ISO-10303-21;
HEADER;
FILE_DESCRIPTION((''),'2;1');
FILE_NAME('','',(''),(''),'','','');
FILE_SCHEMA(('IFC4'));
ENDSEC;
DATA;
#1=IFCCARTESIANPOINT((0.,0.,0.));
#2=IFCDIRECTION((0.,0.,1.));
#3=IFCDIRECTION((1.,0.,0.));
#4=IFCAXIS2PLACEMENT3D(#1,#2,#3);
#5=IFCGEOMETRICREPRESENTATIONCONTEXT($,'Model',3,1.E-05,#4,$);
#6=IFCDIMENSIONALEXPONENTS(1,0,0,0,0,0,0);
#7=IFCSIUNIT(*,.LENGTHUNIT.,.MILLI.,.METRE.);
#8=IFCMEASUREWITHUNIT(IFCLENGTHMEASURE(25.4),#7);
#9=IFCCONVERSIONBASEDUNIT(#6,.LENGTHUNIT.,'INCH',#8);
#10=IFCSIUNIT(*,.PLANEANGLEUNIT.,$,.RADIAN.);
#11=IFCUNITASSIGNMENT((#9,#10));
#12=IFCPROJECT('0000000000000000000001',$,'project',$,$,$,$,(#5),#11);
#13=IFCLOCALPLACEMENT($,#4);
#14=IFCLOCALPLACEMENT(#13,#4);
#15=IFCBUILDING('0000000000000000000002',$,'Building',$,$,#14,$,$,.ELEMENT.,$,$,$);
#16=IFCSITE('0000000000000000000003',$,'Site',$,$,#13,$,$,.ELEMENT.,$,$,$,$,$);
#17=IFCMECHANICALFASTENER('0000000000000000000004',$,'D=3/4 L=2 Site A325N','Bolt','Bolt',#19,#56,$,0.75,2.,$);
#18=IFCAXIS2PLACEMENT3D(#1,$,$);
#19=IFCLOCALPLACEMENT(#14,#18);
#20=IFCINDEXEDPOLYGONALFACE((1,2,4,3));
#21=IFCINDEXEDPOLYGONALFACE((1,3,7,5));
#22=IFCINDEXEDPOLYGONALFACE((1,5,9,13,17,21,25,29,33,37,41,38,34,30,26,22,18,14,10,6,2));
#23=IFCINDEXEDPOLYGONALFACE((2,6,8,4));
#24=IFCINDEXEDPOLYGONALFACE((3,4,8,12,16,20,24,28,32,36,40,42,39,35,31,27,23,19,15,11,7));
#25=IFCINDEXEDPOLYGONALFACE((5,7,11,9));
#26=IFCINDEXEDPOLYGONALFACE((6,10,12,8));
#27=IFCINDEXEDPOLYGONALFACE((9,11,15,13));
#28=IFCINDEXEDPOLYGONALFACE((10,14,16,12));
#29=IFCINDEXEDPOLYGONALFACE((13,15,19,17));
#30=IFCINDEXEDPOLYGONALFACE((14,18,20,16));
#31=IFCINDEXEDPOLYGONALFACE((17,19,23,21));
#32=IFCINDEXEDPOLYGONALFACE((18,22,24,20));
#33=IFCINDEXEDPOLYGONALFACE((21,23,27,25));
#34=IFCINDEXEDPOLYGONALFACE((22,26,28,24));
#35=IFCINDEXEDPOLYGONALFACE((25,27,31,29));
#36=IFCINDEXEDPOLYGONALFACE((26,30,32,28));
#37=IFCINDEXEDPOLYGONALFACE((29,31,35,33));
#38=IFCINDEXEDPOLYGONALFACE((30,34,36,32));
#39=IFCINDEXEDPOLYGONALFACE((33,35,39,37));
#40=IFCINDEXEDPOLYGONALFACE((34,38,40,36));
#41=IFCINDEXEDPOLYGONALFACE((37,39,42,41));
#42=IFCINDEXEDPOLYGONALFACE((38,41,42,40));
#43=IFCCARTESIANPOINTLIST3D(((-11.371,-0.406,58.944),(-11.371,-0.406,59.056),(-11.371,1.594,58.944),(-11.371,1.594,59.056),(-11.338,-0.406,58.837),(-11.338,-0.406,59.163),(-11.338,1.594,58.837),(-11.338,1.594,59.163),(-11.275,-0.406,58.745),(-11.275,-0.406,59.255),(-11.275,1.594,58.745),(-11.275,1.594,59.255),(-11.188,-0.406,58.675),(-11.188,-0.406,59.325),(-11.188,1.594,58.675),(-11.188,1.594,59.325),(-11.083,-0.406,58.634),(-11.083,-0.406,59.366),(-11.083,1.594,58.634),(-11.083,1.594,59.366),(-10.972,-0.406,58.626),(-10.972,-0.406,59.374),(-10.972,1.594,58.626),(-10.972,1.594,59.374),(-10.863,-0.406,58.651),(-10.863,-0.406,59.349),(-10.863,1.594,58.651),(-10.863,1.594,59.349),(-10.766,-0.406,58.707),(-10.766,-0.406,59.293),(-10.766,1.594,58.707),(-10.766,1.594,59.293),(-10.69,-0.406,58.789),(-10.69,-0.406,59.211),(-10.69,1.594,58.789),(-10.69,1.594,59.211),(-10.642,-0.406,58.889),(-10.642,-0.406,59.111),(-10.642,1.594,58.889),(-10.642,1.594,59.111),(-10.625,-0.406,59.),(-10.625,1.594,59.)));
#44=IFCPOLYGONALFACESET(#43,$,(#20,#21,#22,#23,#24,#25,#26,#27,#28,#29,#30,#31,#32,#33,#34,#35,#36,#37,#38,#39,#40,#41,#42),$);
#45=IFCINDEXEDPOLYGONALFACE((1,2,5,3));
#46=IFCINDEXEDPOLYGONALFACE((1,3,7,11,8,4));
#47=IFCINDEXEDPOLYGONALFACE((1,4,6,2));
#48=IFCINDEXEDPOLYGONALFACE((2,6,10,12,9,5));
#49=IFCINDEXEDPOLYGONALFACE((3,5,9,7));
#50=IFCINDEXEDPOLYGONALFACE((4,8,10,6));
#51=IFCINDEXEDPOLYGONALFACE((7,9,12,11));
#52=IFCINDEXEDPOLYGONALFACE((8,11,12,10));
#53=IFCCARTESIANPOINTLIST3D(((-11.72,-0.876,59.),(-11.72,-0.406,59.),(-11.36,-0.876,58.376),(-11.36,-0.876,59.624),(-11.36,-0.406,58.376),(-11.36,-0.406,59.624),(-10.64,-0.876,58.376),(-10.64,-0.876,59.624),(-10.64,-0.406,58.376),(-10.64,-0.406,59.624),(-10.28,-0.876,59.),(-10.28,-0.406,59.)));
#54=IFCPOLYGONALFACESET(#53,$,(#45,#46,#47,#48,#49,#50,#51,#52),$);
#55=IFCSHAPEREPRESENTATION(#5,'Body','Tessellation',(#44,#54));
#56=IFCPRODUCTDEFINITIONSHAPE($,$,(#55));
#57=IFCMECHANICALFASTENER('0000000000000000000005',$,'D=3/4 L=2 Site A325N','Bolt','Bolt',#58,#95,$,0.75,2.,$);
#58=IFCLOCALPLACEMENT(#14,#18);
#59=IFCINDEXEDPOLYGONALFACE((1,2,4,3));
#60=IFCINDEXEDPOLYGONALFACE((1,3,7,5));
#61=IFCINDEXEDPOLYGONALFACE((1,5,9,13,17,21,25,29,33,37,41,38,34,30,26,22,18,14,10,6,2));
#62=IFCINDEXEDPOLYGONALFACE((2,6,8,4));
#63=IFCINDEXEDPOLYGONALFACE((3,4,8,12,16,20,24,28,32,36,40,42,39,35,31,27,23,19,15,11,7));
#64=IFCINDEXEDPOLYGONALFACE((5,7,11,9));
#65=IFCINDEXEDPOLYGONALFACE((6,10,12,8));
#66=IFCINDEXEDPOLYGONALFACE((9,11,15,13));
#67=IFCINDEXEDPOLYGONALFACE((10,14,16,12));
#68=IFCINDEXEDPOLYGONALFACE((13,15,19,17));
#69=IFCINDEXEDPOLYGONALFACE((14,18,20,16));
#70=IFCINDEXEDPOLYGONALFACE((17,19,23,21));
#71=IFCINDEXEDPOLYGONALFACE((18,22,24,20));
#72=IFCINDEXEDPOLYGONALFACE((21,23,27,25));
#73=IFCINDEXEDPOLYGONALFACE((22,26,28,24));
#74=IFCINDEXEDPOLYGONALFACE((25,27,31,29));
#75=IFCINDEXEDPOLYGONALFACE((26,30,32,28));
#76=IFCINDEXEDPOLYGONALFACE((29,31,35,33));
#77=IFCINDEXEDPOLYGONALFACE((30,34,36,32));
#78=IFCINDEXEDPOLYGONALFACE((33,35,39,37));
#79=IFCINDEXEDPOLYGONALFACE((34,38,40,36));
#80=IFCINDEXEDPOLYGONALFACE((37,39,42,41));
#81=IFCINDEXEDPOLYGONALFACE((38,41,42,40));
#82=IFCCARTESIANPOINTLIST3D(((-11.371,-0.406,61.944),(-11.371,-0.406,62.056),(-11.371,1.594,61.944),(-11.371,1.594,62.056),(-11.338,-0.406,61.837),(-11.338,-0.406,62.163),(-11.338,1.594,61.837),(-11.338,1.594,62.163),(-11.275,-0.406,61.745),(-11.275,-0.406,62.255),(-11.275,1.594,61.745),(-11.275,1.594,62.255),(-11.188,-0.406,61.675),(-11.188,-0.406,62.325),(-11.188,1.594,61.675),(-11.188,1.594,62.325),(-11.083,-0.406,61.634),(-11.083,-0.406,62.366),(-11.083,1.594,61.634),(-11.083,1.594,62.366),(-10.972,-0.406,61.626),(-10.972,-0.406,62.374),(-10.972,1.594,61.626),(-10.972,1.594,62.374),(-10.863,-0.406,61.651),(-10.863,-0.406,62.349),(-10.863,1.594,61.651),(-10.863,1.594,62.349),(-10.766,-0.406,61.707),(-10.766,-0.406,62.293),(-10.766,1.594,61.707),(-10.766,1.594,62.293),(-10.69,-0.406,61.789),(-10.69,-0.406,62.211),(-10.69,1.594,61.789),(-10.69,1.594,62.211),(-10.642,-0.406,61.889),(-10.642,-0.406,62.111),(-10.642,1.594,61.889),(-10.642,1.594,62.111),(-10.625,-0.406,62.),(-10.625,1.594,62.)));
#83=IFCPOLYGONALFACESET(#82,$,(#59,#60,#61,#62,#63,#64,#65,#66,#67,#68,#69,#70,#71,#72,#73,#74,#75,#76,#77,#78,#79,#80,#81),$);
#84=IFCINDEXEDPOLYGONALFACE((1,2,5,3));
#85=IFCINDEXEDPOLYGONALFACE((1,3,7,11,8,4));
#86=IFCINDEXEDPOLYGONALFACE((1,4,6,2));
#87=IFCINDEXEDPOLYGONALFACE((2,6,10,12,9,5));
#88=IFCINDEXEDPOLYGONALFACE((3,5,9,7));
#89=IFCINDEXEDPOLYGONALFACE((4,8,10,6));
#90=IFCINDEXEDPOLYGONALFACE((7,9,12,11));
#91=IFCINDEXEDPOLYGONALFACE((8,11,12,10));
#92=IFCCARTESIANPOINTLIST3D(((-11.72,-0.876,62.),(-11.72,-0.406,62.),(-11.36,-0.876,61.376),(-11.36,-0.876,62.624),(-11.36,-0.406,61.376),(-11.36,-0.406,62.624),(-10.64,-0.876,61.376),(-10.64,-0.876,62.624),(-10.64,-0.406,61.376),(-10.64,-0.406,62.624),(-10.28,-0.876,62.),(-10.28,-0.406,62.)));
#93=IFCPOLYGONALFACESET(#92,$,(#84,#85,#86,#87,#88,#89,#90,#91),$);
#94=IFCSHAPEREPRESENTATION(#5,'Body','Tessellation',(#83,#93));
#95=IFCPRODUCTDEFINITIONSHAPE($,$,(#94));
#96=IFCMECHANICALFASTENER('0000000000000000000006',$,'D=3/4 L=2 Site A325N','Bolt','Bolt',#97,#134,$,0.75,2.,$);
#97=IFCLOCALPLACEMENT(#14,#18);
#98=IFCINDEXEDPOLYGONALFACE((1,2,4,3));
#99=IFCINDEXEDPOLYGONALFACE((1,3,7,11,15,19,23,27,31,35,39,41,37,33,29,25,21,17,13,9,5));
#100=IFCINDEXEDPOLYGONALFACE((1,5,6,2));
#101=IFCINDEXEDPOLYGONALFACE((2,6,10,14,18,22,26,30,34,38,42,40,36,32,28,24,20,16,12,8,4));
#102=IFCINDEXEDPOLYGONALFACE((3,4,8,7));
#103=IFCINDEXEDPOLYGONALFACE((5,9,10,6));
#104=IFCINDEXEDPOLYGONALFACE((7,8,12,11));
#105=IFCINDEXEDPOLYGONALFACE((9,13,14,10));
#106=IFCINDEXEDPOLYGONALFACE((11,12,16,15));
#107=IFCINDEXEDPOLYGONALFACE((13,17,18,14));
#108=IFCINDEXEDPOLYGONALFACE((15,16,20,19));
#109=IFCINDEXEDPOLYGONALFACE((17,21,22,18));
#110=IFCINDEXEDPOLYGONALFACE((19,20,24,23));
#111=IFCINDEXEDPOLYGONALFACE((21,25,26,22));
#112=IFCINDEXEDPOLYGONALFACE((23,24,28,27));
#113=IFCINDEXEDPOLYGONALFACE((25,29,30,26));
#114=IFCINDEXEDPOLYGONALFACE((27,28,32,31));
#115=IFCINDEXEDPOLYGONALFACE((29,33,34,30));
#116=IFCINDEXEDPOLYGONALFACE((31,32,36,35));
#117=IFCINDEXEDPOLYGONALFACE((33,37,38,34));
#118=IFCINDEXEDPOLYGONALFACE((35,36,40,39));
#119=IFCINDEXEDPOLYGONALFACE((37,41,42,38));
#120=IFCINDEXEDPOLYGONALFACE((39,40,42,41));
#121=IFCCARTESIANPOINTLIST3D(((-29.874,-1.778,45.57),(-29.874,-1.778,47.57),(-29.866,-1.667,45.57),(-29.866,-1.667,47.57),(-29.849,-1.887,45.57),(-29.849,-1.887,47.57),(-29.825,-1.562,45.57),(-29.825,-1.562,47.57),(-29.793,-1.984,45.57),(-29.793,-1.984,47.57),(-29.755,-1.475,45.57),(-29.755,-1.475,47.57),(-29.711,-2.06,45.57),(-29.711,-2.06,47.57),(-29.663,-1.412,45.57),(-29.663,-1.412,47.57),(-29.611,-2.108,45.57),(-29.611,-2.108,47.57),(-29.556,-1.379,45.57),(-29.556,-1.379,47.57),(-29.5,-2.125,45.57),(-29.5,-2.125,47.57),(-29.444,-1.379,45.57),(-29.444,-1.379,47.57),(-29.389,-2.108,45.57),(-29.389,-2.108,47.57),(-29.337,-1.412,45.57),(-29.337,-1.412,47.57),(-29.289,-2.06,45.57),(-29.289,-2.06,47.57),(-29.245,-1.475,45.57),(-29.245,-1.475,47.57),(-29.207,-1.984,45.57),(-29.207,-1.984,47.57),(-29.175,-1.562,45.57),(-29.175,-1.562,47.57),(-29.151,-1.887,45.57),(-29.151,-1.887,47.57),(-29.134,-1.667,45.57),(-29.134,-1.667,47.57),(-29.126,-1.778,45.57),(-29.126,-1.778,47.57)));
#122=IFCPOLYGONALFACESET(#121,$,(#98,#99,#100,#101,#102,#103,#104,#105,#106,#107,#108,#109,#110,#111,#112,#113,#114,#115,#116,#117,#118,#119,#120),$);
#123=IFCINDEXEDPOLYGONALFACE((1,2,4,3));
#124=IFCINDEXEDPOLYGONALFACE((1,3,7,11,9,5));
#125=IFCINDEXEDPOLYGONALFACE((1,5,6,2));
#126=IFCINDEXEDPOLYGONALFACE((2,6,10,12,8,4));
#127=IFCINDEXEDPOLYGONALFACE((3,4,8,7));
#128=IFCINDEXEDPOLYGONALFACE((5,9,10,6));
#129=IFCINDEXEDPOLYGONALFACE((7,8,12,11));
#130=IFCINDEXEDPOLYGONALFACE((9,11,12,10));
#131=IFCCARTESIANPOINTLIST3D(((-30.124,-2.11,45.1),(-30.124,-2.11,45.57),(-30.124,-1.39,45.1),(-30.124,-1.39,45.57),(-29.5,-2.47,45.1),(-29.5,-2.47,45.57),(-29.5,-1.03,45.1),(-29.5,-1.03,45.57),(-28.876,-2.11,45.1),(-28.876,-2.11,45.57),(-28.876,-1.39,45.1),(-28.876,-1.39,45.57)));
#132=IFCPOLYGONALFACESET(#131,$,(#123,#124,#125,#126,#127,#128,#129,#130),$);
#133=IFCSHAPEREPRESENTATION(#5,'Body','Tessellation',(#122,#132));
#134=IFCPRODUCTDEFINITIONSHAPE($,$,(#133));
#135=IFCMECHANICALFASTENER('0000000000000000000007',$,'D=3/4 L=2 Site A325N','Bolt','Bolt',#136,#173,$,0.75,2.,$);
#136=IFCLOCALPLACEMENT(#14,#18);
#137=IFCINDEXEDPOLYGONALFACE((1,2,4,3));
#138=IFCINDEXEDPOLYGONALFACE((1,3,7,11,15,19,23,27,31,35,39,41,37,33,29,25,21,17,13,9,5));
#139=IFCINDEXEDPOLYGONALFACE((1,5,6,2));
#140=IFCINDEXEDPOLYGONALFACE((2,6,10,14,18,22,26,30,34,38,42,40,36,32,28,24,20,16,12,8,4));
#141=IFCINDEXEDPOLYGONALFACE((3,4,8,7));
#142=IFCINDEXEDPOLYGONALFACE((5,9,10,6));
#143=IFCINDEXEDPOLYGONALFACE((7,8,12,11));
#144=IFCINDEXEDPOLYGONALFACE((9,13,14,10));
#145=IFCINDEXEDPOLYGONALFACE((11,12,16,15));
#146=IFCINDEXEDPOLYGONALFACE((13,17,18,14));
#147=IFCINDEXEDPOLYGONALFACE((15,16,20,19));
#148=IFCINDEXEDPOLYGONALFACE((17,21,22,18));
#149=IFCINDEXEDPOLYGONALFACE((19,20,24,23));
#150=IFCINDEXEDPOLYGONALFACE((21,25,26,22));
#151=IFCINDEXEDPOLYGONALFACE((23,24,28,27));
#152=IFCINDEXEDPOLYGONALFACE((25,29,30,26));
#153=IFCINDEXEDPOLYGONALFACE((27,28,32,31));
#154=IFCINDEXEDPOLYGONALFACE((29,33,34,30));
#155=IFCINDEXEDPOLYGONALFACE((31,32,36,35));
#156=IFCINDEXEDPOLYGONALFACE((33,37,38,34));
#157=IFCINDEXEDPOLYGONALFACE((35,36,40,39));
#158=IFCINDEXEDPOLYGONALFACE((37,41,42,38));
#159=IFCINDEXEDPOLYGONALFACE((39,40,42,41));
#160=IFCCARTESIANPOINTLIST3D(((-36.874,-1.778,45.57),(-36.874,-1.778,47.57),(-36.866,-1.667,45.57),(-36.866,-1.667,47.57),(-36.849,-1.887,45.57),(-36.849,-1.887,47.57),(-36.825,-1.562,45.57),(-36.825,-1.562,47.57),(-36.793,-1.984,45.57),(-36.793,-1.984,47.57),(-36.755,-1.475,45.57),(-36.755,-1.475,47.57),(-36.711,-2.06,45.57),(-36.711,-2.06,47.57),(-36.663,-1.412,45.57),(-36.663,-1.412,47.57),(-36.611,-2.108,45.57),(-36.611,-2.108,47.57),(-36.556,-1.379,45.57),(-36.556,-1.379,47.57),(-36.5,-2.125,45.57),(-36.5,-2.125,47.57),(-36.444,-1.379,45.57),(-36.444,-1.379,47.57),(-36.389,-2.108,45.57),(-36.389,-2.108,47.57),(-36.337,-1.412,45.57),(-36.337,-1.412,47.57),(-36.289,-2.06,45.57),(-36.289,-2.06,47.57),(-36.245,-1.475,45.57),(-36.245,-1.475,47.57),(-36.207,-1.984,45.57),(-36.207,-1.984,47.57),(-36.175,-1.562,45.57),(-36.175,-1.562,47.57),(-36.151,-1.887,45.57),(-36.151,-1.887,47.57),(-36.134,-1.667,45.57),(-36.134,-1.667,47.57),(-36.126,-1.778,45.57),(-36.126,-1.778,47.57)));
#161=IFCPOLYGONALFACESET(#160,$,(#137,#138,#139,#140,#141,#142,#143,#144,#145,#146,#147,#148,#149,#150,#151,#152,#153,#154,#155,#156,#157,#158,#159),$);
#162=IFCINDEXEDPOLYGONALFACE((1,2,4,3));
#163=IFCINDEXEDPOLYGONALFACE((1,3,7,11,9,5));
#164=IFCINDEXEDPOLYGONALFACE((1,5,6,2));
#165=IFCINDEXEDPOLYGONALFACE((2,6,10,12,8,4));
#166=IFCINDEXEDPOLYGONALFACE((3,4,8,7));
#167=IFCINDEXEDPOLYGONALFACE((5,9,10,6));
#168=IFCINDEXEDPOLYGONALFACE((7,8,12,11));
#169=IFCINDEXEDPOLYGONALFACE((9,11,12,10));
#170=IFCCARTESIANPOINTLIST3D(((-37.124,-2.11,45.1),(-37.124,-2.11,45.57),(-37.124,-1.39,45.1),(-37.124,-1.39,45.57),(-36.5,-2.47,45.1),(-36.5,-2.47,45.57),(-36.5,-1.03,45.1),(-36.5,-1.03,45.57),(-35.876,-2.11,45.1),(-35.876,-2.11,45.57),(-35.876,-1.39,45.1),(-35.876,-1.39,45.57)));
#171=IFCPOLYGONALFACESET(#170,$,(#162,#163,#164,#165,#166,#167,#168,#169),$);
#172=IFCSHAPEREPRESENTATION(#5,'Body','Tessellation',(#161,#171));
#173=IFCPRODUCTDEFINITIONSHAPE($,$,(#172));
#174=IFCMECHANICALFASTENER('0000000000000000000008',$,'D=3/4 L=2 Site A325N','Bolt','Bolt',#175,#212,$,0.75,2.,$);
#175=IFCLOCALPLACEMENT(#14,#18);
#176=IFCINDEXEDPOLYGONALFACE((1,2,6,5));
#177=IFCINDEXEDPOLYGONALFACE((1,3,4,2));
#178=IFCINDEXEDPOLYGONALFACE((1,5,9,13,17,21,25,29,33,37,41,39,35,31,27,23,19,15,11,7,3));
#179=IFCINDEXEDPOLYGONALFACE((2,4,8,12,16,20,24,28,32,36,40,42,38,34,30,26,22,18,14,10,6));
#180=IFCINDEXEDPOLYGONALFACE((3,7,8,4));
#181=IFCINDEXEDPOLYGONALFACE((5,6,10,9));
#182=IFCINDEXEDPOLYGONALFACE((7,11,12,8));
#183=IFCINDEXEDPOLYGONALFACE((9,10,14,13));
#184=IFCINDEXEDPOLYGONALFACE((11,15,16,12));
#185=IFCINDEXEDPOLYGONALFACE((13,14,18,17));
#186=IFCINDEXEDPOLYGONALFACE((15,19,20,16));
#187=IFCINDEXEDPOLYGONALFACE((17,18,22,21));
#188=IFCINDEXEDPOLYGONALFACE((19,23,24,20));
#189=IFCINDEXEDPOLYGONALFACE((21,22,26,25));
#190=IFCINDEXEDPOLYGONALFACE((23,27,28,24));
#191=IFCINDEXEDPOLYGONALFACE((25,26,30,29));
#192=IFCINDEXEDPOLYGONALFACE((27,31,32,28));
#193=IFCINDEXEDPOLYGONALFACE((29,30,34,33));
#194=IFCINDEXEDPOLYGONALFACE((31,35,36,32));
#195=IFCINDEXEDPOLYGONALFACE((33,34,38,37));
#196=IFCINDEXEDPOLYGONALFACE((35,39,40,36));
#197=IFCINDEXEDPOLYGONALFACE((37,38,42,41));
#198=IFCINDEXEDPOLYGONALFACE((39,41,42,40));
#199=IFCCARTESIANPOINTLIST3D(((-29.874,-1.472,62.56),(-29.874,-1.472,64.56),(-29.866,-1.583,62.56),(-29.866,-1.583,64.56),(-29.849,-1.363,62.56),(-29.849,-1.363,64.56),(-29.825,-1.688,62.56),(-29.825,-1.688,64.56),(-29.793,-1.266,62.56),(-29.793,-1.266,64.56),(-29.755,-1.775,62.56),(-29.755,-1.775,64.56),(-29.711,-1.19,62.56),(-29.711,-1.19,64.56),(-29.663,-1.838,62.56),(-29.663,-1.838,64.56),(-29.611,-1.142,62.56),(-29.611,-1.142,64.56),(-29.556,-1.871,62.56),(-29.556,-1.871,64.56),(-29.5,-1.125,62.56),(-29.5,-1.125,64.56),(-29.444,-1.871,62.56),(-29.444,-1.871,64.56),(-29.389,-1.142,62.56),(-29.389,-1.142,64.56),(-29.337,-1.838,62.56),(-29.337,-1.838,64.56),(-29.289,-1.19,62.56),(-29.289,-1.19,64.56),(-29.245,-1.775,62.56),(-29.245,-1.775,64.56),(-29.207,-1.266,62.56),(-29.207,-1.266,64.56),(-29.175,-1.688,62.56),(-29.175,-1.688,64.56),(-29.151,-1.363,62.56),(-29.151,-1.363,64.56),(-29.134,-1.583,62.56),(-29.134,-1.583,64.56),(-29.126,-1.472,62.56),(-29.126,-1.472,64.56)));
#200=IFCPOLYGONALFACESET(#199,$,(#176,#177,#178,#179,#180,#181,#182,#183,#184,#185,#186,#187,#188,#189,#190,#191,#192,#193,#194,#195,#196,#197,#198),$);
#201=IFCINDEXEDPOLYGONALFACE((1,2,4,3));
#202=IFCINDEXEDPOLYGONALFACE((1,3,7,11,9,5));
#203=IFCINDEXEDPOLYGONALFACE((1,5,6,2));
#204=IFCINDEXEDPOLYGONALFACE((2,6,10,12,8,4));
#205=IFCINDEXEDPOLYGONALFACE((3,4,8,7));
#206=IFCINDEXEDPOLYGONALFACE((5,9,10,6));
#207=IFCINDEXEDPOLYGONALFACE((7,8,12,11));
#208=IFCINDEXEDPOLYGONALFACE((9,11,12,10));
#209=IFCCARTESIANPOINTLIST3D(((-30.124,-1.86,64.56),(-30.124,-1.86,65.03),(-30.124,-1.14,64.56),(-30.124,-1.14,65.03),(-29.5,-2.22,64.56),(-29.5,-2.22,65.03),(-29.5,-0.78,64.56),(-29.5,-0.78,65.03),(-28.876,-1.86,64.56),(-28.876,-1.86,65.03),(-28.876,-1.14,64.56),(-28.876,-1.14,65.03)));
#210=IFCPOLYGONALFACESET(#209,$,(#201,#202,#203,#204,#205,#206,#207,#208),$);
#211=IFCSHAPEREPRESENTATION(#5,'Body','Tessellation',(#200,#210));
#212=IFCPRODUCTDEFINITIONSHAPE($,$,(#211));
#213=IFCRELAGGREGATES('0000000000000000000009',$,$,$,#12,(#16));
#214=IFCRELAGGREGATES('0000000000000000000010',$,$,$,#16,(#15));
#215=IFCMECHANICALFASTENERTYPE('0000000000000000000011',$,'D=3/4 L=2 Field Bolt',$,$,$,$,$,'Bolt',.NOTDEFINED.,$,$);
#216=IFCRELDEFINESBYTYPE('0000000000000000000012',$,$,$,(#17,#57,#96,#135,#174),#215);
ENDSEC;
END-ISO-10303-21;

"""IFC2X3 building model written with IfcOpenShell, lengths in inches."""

from ifc_helpers import new_model, entity, si_unit, converted_unit, frame, origin_with_axes, origin_2d_with_axis, place, context, project, spatial, polyline, circle, outline, extrude, source, transform, mapped, type_object, type_shapes, element, save


model = new_model("IFC2X3")

# Units and contexts
model_context = context("Model", 3, precision=1e-05, world=origin_with_axes())
ifc_project = project(units=[converted_unit("LENGTHUNIT", "INCH", entity("IfcLengthMeasure", 25.4), si_unit("LENGTHUNIT", "METRE", prefix="MILLI"), dimensions=[1, 0, 0, 0, 0, 0, 0]), si_unit("PLANEANGLEUNIT", "RADIAN")], contexts=[model_context])

# Site, building
site_placement = place(None, origin_with_axes())
site = spatial("IfcSite", under=ifc_project, at=site_placement, Name="Site", CompositionType="ELEMENT")
building_placement = place(site_placement, origin_with_axes())
building = spatial("IfcBuilding", under=site, at=building_placement, Name="Building", CompositionType="ELEMENT")

# Mechanical fasteners
mechanical_fastener_type_1 = type_object("IfcMechanicalFastenerType", Name="D=3/4 L=2 Field Bolt", ElementType="Bolt")
shared_shape_1 = source(origin_with_axes(), model_context, "Body", "SweptSolid", [
    extrude(circle(Radius=0.375, at=origin_2d_with_axis()), frame((0.0, 0.0, 0.0), z_axis=(1.0, 0.0, 0.0), x_axis=(0.0, 1.0, 0.0)), (0.0, 0.0, 1.0), 2.0),
    extrude(outline(polyline([(-0.72, 0.0), (-0.36, 0.624), (0.36, 0.624), (0.72, 0.0), (0.36, -0.624), (-0.36, -0.624), (-0.72, 0.0)])), frame((0.0, 0.0, 0.0), z_axis=(1.0, 0.0, 0.0), x_axis=(0.0, 1.0, 0.0)), (0.0, 0.0, -1.0), 0.47),
])
type_shapes(mechanical_fastener_type_1, [shared_shape_1])
placement_1 = place(building_placement, frame((-9.25, 0.0, 50.0), z_axis=(-1.0, 0.0, 0.0), x_axis=(0.0, 0.0, 1.0)))
placement_2 = place(placement_1, frame((9.0, -0.406, 1.75), z_axis=(-1.0, 0.0, 0.0), x_axis=(0.0, 1.0, 0.0)))
for number, where, z_axis, x_axis, name in (
    (1, (0.0, 0.0, 0.0), (0.0, 0.0, 1.0), (1.0, 0.0, 0.0), "D=3/4 L=2 Site A325N"),
    (2, (0.0, 0.0, -3.0), (0.0, 0.0, 1.0), (1.0, 0.0, 0.0), "D=3/4 L=2 Site A325N"),
):
    element("IfcMechanicalFastener", number, at=place(placement_2, frame(where, z_axis=z_axis, x_axis=x_axis)), type_object=mechanical_fastener_type_1, Name=name, Description="Bolt", ObjectType="Bolt", NominalDiameter=0.75, NominalLength=2.0, context=model_context, shape_type="MappedRepresentation", body=[
        mapped(shared_shape_1, transform((0.0, 0.0, 0.0), scale=1.0)),
    ])
placement_3 = place(building_placement, frame((-33.0, 0.0, 46.0), z_axis=(-1.0, 0.0, 0.0), x_axis=(0.0, 0.0, 1.0)))
placement_4 = place(placement_3, frame((-0.43, 1.75, 3.5), z_axis=(0.0, 0.0, -1.0), x_axis=(1.0, 0.0, 0.0)))
for number, where, z_axis, x_axis, name in (
    (3, (0.0, 3.5, 7.0), (0.0, 0.0, 1.0), (1.0, 0.0, 0.0), "D=3/4 L=2 Site A325N"),
    (4, (0.0, 3.5, 0.0), (0.0, 0.0, 1.0), (1.0, 0.0, 0.0), "D=3/4 L=2 Site A325N"),
):
    element("IfcMechanicalFastener", number, at=place(placement_4, frame(where, z_axis=z_axis, x_axis=x_axis)), type_object=mechanical_fastener_type_1, Name=name, Description="Bolt", ObjectType="Bolt", NominalDiameter=0.75, NominalLength=2.0, context=model_context, shape_type="MappedRepresentation", body=[
        mapped(shared_shape_1, transform((0.0, 0.0, 0.0), scale=1.0)),
    ])
placement_5 = place(placement_3, frame((18.56, -1.5, 3.5), z_axis=(0.0, 0.0, -1.0), x_axis=(-1.0, 0.0, 0.0)))
for number, where, z_axis, x_axis, name in (
    (5, (0.0, 0.0, 7.0), (0.0, 0.0, 1.0), (1.0, 0.0, 0.0), "D=3/4 L=2 Site A325N"),
):
    element("IfcMechanicalFastener", number, at=place(placement_5, frame(where, z_axis=z_axis, x_axis=x_axis)), type_object=mechanical_fastener_type_1, Name=name, Description="Bolt", ObjectType="Bolt", NominalDiameter=0.75, NominalLength=2.0, context=model_context, shape_type="MappedRepresentation", body=[
        mapped(shared_shape_1, transform((0.0, 0.0, 0.0), scale=1.0)),
    ])

save(model, "model.ifc")
